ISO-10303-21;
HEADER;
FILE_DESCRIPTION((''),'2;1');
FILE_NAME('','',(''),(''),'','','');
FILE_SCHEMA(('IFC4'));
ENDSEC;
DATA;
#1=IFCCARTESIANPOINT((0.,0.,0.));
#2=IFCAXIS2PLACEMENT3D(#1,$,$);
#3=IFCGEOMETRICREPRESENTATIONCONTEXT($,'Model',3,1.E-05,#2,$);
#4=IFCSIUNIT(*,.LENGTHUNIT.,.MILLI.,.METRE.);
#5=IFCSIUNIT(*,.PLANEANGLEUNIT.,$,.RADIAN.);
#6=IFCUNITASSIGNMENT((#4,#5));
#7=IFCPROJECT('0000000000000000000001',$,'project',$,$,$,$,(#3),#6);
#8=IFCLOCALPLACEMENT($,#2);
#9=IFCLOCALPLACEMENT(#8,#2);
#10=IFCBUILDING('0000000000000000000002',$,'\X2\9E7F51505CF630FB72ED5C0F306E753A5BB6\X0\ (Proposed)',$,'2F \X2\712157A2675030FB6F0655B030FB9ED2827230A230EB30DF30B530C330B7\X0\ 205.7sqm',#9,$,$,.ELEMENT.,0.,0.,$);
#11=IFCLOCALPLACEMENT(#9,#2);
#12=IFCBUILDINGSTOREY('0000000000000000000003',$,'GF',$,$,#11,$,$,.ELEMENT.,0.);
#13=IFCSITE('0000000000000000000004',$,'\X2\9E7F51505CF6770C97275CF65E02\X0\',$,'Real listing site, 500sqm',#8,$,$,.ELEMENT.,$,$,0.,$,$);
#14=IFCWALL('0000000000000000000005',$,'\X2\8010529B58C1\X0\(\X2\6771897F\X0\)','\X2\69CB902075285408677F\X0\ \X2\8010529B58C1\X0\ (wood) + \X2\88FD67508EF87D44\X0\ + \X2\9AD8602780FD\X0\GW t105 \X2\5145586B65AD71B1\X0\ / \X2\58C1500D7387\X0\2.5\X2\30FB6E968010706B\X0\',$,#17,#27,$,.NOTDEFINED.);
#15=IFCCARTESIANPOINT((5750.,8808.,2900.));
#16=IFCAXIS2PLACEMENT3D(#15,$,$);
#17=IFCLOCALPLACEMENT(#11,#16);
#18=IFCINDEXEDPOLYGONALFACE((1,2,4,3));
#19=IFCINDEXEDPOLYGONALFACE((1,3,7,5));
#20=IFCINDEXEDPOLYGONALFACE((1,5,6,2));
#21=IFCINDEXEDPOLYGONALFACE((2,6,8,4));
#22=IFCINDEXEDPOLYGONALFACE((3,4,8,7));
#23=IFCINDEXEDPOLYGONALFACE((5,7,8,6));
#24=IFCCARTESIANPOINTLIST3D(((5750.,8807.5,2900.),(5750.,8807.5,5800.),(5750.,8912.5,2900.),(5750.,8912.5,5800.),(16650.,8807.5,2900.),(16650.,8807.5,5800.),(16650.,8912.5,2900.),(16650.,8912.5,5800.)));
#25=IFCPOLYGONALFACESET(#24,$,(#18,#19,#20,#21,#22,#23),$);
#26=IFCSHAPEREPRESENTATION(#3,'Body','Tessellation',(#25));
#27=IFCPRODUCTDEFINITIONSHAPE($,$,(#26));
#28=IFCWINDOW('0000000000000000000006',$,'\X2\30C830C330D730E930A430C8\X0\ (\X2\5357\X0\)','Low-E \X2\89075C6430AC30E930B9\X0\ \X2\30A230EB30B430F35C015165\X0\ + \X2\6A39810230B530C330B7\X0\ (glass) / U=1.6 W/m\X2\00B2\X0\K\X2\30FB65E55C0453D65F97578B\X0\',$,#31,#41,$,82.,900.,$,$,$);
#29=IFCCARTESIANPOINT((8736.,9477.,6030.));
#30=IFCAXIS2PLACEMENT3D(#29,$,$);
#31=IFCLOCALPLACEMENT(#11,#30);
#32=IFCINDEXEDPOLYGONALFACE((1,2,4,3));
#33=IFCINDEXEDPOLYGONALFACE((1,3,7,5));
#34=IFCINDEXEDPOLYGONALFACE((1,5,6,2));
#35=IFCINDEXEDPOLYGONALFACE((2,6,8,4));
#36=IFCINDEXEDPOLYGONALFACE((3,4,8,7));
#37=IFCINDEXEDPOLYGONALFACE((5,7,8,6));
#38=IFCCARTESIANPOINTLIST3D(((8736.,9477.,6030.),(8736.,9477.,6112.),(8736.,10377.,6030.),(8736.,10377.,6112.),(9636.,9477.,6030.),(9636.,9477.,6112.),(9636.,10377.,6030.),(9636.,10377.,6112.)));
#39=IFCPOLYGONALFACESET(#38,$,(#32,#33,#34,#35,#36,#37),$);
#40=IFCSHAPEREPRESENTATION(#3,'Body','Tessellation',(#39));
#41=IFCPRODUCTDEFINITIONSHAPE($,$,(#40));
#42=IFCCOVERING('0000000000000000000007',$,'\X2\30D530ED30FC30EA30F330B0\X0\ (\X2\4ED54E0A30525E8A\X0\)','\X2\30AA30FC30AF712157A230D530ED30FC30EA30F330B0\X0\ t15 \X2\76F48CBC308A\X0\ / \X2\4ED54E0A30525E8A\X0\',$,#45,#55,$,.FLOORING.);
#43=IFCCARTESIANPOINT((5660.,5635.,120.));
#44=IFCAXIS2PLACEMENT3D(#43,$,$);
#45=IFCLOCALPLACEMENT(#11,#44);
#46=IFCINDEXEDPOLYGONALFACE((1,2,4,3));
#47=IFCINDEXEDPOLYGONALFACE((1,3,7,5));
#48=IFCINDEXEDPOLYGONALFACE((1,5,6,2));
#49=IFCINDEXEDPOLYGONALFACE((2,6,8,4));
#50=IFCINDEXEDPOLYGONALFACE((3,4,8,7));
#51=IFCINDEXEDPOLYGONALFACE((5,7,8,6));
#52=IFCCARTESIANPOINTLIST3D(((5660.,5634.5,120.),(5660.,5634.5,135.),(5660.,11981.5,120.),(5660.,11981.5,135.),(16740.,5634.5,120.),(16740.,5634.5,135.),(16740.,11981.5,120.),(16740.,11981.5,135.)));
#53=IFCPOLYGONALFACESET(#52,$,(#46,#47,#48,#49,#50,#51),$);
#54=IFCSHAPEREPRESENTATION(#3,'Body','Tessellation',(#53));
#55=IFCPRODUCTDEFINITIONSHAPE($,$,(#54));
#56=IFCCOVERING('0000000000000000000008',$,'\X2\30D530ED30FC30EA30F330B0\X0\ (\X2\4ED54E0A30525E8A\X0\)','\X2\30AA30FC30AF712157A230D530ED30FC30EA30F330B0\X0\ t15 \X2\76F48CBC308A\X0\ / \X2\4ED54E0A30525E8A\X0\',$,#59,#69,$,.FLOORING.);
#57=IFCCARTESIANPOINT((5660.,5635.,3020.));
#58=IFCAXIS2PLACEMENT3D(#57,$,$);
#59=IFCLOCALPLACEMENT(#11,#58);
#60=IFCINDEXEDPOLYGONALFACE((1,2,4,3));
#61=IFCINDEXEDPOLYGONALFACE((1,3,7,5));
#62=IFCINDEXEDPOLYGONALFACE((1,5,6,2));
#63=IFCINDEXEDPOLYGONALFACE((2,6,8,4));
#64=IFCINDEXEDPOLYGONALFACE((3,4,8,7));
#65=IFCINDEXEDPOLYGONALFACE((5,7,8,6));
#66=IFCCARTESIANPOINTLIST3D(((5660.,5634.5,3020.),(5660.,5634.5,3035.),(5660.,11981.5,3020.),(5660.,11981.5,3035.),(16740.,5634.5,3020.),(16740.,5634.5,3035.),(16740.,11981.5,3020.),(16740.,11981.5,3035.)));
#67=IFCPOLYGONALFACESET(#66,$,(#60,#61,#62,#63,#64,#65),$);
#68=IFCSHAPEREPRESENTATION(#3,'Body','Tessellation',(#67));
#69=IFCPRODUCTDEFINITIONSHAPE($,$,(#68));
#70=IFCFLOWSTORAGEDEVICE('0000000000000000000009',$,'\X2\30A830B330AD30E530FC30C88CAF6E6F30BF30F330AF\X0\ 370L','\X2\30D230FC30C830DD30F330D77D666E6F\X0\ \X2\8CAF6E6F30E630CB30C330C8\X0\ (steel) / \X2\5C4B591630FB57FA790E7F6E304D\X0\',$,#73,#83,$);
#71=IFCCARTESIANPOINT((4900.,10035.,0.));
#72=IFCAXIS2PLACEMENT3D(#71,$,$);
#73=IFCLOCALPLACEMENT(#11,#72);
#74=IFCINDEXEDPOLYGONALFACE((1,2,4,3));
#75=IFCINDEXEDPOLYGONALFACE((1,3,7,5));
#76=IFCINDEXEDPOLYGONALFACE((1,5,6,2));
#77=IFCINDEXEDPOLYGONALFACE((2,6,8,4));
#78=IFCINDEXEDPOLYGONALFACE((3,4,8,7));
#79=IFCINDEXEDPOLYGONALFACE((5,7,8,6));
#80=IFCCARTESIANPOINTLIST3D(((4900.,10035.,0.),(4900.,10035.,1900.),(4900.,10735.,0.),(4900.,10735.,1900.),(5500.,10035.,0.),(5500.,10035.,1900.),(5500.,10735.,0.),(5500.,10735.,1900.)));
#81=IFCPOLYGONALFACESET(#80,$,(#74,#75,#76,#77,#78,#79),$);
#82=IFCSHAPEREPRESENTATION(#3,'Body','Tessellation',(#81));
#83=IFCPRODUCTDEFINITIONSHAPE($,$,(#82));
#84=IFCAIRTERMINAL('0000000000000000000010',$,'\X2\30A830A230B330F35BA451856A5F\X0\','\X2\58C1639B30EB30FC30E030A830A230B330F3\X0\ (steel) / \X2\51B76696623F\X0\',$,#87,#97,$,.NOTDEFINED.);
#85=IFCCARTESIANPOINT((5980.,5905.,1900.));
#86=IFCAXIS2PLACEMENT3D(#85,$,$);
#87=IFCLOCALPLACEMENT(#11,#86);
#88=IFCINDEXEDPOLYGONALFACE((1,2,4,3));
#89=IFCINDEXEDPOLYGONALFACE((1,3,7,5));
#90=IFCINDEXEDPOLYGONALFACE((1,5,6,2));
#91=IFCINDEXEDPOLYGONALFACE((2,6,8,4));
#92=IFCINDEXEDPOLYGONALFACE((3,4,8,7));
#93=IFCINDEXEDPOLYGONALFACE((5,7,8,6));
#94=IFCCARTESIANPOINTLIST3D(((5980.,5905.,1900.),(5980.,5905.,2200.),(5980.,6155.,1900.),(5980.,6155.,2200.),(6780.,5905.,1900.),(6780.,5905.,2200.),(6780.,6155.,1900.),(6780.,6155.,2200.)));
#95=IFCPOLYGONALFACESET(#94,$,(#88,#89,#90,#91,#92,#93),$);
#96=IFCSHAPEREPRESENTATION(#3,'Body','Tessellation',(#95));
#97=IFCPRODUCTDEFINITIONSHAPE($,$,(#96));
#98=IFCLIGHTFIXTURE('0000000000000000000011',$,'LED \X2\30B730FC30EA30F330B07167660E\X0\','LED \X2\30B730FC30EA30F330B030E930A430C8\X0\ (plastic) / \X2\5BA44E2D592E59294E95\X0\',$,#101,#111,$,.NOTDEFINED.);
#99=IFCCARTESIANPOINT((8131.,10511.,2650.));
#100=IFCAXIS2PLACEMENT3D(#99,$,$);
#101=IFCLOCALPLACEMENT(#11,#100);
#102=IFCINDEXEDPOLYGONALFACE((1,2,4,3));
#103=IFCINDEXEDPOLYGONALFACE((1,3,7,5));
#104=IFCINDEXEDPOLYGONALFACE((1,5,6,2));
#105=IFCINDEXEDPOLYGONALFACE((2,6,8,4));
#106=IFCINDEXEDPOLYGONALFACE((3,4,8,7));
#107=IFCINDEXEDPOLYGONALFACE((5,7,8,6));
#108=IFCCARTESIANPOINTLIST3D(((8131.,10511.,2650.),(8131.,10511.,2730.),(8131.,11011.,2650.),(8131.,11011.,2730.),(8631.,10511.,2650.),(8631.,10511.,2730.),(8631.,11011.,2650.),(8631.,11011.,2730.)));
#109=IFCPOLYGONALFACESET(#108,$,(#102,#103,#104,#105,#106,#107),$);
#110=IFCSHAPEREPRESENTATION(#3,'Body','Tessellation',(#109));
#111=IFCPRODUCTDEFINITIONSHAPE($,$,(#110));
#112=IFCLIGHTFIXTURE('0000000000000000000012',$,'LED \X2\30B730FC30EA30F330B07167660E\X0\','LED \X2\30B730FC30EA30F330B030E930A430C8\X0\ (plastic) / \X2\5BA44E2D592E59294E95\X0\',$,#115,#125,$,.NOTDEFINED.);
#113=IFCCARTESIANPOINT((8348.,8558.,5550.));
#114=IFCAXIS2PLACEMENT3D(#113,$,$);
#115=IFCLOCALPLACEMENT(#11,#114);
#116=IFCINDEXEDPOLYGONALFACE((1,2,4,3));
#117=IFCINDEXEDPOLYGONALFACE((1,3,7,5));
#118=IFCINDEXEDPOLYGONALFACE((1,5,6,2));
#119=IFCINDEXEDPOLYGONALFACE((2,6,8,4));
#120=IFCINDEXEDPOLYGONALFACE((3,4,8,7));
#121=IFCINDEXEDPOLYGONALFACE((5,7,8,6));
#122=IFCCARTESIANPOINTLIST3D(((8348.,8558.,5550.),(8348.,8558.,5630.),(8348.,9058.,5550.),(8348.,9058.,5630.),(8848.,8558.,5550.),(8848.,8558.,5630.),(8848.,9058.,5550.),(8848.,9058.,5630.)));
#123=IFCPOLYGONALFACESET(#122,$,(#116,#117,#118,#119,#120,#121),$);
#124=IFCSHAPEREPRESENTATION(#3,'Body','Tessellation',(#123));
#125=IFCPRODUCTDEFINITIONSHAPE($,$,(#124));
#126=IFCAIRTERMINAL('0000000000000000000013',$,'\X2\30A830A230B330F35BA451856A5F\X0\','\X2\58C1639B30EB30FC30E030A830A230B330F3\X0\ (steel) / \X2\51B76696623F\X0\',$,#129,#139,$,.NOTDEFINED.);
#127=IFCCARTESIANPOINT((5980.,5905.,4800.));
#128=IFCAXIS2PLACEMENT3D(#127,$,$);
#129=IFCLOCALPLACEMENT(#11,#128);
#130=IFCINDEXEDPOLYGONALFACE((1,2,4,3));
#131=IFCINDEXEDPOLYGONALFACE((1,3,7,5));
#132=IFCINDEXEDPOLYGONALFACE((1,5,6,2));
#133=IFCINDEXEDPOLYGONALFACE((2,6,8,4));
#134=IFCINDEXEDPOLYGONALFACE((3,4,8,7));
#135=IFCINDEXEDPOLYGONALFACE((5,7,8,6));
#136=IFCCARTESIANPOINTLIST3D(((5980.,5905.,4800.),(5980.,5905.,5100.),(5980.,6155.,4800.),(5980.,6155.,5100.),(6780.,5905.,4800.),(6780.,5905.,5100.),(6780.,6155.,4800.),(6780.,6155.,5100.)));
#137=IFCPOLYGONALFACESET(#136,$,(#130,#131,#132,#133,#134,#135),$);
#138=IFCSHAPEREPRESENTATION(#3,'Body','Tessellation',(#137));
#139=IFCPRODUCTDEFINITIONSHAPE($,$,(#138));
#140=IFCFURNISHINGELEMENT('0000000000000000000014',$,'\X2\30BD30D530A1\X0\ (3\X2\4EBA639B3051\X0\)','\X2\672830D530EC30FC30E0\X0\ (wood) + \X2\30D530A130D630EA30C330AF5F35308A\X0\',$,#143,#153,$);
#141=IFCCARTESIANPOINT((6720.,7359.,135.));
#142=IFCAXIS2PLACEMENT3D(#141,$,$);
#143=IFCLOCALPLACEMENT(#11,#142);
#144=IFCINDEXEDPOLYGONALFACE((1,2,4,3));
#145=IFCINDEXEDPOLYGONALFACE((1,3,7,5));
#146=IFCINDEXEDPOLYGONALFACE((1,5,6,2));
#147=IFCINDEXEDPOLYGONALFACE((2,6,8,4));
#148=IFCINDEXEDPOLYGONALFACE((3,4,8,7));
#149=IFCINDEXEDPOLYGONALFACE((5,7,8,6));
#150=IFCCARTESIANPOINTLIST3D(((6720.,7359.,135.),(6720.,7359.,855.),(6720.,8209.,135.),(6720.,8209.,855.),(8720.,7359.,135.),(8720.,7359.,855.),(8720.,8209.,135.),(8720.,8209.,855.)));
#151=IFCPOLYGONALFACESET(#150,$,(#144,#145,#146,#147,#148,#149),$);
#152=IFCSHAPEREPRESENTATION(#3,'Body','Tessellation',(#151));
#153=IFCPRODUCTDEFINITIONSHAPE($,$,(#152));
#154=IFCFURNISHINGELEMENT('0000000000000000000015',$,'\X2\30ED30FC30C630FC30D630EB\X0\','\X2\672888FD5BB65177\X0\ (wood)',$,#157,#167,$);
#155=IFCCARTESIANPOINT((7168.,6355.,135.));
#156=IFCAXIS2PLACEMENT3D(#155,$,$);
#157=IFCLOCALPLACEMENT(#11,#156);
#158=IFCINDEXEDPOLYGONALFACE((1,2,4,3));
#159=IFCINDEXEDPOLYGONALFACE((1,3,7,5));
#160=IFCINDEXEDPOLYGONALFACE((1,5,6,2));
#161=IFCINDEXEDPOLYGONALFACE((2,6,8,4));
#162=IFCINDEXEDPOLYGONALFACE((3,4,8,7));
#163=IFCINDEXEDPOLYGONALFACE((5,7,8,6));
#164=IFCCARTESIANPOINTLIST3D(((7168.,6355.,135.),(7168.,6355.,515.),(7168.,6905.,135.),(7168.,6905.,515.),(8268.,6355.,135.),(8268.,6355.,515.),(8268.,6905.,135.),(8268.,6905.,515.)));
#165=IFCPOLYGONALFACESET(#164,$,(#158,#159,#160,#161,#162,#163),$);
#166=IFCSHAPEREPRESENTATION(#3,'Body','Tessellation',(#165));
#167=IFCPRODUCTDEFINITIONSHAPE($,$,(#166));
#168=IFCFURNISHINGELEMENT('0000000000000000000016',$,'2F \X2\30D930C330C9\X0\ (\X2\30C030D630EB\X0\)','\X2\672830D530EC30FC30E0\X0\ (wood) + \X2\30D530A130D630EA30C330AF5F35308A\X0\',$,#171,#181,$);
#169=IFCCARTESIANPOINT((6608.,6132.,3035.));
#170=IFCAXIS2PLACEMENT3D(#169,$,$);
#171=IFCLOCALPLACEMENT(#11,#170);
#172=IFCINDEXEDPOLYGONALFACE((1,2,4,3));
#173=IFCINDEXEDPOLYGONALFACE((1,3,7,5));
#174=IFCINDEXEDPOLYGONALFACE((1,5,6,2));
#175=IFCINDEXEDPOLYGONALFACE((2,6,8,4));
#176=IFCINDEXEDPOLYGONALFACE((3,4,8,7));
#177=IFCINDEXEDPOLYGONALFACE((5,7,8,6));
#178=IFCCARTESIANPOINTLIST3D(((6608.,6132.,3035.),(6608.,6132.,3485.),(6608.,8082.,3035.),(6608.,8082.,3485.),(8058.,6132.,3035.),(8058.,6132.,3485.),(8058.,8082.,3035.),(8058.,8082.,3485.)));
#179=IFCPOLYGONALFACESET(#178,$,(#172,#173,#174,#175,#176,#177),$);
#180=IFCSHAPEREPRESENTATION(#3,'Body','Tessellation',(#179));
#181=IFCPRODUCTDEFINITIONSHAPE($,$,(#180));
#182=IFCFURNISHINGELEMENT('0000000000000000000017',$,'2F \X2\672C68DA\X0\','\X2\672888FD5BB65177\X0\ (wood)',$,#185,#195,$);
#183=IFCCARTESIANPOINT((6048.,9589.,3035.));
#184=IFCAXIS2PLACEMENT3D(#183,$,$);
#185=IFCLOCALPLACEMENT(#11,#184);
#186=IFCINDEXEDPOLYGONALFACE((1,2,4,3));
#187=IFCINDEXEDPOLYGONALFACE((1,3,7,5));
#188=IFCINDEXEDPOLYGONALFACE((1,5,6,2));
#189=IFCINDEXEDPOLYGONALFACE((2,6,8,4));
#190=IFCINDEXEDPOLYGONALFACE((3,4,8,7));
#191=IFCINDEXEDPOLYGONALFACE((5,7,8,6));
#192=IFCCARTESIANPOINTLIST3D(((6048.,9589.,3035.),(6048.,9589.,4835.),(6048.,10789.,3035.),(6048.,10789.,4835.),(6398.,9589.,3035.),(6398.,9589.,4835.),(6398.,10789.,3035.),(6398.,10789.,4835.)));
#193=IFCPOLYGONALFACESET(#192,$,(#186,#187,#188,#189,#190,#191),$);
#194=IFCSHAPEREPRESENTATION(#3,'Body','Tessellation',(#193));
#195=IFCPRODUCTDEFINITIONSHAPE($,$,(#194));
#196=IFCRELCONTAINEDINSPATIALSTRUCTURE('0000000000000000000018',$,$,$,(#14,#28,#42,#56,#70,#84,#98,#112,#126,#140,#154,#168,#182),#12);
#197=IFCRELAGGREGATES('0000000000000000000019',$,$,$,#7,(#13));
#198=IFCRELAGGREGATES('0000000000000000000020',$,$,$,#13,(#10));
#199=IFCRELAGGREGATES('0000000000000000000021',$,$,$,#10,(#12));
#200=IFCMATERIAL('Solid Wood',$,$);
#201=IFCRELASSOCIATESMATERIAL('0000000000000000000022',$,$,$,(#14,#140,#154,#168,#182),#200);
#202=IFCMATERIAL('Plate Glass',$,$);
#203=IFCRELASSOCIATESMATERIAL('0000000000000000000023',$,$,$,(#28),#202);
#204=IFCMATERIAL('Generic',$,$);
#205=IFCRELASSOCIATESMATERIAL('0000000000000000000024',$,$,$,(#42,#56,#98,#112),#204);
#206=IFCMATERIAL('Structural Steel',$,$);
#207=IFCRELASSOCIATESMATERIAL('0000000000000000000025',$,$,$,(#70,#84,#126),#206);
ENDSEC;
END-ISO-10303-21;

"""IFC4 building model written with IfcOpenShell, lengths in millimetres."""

from ifc_helpers import new_model, si_unit, frame, frame_2d, origin, place, context, project, spatial, rectangle, extrude, material, element, save


model = new_model("IFC4")

# Units and contexts
model_context = context("Model", 3, precision=1e-05, world=origin())
ifc_project = project(units=[si_unit("LENGTHUNIT", "METRE", prefix="MILLI"), si_unit("PLANEANGLEUNIT", "RADIAN")], contexts=[model_context])

# Site, building, storey
site_placement = place(None, origin())
site = spatial("IfcSite", under=ifc_project, at=site_placement, Name="鹿児島県霧島市", ObjectType="Real listing site, 500sqm", CompositionType="ELEMENT", RefElevation=0.0)
building_placement = place(site_placement, origin())
building = spatial("IfcBuilding", under=site, at=building_placement, Name="鹿児島・狭小の町家 (Proposed)", ObjectType="2F 無垢材・漆喰・黒色アルミサッシ 205.7sqm", CompositionType="ELEMENT", ElevationOfRefHeight=0.0, ElevationOfTerrain=0.0)
storey_placement = place(building_placement, origin())
storey = spatial("IfcBuildingStorey", under=building, at=storey_placement, Name="GF", CompositionType="ELEMENT", Elevation=0.0)

# Shared definitions
ifc_material_1 = material(Name="Solid Wood")

# Wall
wall_1_placement = place(storey_placement, frame((5750.0, 8808.0, 2900.0)))
element("IfcWall", 1, at=wall_1_placement, inside=storey, material=ifc_material_1, Name="耐力壁(東西)", Description="構造用合板 耐力壁 (wood) + 製材軸組 + 高性能GW t105 充填断熱 / 壁倍率2.5・準耐火", PredefinedType="NOTDEFINED", context=model_context, shape_type="SweptSolid", body=[
    extrude(rectangle(XDim=10900.0, YDim=105.0, at=frame_2d((5450.0, 52.0))), frame((5750.0, 8808.0, 2900.0)), (0.0, 0.0, 1.0), 2900.0),
])

# Window
ifc_material_2 = material(Name="Plate Glass")
window_placement = place(storey_placement, frame((8736.0, 9477.0, 6030.0)))
element("IfcWindow", 2, at=window_placement, inside=storey, material=ifc_material_2, Name="トップライト (南)", Description="Low-E 複層ガラス アルゴン封入 + 樹脂サッシ (glass) / U=1.6 W/m²K・日射取得型", OverallHeight=82.0, OverallWidth=900.0, context=model_context, shape_type="SweptSolid", body=[
    extrude(rectangle(XDim=900.0, YDim=900.0, at=frame_2d((450.0, 450.0))), frame((8736.0, 9477.0, 6030.0)), (0.0, 0.0, 1.0), 82.0),
])

# Coverings
ifc_material_3 = material(Name="Generic")
covering_1_placement = place(storey_placement, frame((5660.0, 5635.0, 120.0)))
element("IfcCovering", 3, at=covering_1_placement, inside=storey, material=ifc_material_3, Name="フローリング (仕上げ床)", Description="オーク無垢フローリング t15 直貼り / 仕上げ床", PredefinedType="FLOORING", context=model_context, shape_type="SweptSolid", body=[
    extrude(rectangle(XDim=11080.0, YDim=6347.0, at=frame_2d((5540.0, 3173.0))), frame((5660.0, 5635.0, 120.0)), (0.0, 0.0, 1.0), 15.0),
])
covering_2_placement = place(storey_placement, frame((5660.0, 5635.0, 3020.0)))
element("IfcCovering", 4, at=covering_2_placement, inside=storey, material=ifc_material_3, Name="フローリング (仕上げ床)", Description="オーク無垢フローリング t15 直貼り / 仕上げ床", PredefinedType="FLOORING", context=model_context, shape_type="SweptSolid", body=[
    extrude(rectangle(XDim=11080.0, YDim=6347.0, at=frame_2d((5540.0, 3173.0))), frame((5660.0, 5635.0, 3020.0)), (0.0, 0.0, 1.0), 15.0),
])

# Flow storage device
ifc_material_4 = material(Name="Structural Steel")
flow_storage_device_placement = place(storey_placement, frame((4900.0, 10035.0, 0.0)))
element("IfcFlowStorageDevice", 5, at=flow_storage_device_placement, inside=storey, material=ifc_material_4, Name="エコキュート貯湯タンク 370L", Description="ヒートポンプ給湯 貯湯ユニット (steel) / 屋外・基礎置き", context=model_context, shape_type="SweptSolid", body=[
    extrude(rectangle(XDim=600.0, YDim=700.0, at=frame_2d((300.0, 350.0))), frame((4900.0, 10035.0, 0.0)), (0.0, 0.0, 1.0), 1900.0),
])

# Air terminal
air_terminal_1_placement = place(storey_placement, frame((5980.0, 5905.0, 1900.0)))
element("IfcAirTerminal", 6, at=air_terminal_1_placement, inside=storey, material=ifc_material_4, Name="エアコン室内機", Description="壁掛ルームエアコン (steel) / 冷暖房", PredefinedType="NOTDEFINED", context=model_context, shape_type="SweptSolid", body=[
    extrude(rectangle(XDim=800.0, YDim=250.0, at=frame_2d((400.0, 125.0))), frame((5980.0, 5905.0, 1900.0)), (0.0, 0.0, 1.0), 300.0),
])

# Light fixtures
light_fixture_1_placement = place(storey_placement, frame((8131.0, 10511.0, 2650.0)))
element("IfcLightFixture", 7, at=light_fixture_1_placement, inside=storey, material=ifc_material_3, Name="LED シーリング照明", Description="LED シーリングライト (plastic) / 室中央天井", PredefinedType="NOTDEFINED", context=model_context, shape_type="SweptSolid", body=[
    extrude(rectangle(XDim=500.0, YDim=500.0, at=frame_2d((250.0, 250.0))), frame((8131.0, 10511.0, 2650.0)), (0.0, 0.0, 1.0), 80.0),
])
light_fixture_2_placement = place(storey_placement, frame((8348.0, 8558.0, 5550.0)))
element("IfcLightFixture", 8, at=light_fixture_2_placement, inside=storey, material=ifc_material_3, Name="LED シーリング照明", Description="LED シーリングライト (plastic) / 室中央天井", PredefinedType="NOTDEFINED", context=model_context, shape_type="SweptSolid", body=[
    extrude(rectangle(XDim=500.0, YDim=500.0, at=frame_2d((250.0, 250.0))), frame((8348.0, 8558.0, 5550.0)), (0.0, 0.0, 1.0), 80.0),
])

# Air terminal
air_terminal_2_placement = place(storey_placement, frame((5980.0, 5905.0, 4800.0)))
element("IfcAirTerminal", 9, at=air_terminal_2_placement, inside=storey, material=ifc_material_4, Name="エアコン室内機", Description="壁掛ルームエアコン (steel) / 冷暖房", PredefinedType="NOTDEFINED", context=model_context, shape_type="SweptSolid", body=[
    extrude(rectangle(XDim=800.0, YDim=250.0, at=frame_2d((400.0, 125.0))), frame((5980.0, 5905.0, 4800.0)), (0.0, 0.0, 1.0), 300.0),
])

# Furnishing elements
furnishing_1_placement = place(storey_placement, frame((6720.0, 7359.0, 135.0)))
element("IfcFurnishingElement", 10, at=furnishing_1_placement, inside=storey, material=ifc_material_1, Name="ソファ (3人掛け)", Description="木フレーム (wood) + ファブリック張り", context=model_context, shape_type="SweptSolid", body=[
    extrude(rectangle(XDim=2000.0, YDim=850.0, at=frame_2d((1000.0, 425.0))), frame((6720.0, 7359.0, 135.0)), (0.0, 0.0, 1.0), 720.0),
])
furnishing_2_placement = place(storey_placement, frame((7168.0, 6355.0, 135.0)))
element("IfcFurnishingElement", 11, at=furnishing_2_placement, inside=storey, material=ifc_material_1, Name="ローテーブル", Description="木製家具 (wood)", context=model_context, shape_type="SweptSolid", body=[
    extrude(rectangle(XDim=1100.0, YDim=550.0, at=frame_2d((550.0, 275.0))), frame((7168.0, 6355.0, 135.0)), (0.0, 0.0, 1.0), 380.0),
])
furnishing_3_placement = place(storey_placement, frame((6608.0, 6132.0, 3035.0)))
element("IfcFurnishingElement", 12, at=furnishing_3_placement, inside=storey, material=ifc_material_1, Name="2F ベッド (ダブル)", Description="木フレーム (wood) + ファブリック張り", context=model_context, shape_type="SweptSolid", body=[
    extrude(rectangle(XDim=1450.0, YDim=1950.0, at=frame_2d((725.0, 975.0))), frame((6608.0, 6132.0, 3035.0)), (0.0, 0.0, 1.0), 450.0),
])
furnishing_4_placement = place(storey_placement, frame((6048.0, 9589.0, 3035.0)))
element("IfcFurnishingElement", 13, at=furnishing_4_placement, inside=storey, material=ifc_material_1, Name="2F 本棚", Description="木製家具 (wood)", context=model_context, shape_type="SweptSolid", body=[
    extrude(rectangle(XDim=350.0, YDim=1200.0, at=frame_2d((175.0, 600.0))), frame((6048.0, 9589.0, 3035.0)), (0.0, 0.0, 1.0), 1800.0),
])

save(model, "model.ifc")
